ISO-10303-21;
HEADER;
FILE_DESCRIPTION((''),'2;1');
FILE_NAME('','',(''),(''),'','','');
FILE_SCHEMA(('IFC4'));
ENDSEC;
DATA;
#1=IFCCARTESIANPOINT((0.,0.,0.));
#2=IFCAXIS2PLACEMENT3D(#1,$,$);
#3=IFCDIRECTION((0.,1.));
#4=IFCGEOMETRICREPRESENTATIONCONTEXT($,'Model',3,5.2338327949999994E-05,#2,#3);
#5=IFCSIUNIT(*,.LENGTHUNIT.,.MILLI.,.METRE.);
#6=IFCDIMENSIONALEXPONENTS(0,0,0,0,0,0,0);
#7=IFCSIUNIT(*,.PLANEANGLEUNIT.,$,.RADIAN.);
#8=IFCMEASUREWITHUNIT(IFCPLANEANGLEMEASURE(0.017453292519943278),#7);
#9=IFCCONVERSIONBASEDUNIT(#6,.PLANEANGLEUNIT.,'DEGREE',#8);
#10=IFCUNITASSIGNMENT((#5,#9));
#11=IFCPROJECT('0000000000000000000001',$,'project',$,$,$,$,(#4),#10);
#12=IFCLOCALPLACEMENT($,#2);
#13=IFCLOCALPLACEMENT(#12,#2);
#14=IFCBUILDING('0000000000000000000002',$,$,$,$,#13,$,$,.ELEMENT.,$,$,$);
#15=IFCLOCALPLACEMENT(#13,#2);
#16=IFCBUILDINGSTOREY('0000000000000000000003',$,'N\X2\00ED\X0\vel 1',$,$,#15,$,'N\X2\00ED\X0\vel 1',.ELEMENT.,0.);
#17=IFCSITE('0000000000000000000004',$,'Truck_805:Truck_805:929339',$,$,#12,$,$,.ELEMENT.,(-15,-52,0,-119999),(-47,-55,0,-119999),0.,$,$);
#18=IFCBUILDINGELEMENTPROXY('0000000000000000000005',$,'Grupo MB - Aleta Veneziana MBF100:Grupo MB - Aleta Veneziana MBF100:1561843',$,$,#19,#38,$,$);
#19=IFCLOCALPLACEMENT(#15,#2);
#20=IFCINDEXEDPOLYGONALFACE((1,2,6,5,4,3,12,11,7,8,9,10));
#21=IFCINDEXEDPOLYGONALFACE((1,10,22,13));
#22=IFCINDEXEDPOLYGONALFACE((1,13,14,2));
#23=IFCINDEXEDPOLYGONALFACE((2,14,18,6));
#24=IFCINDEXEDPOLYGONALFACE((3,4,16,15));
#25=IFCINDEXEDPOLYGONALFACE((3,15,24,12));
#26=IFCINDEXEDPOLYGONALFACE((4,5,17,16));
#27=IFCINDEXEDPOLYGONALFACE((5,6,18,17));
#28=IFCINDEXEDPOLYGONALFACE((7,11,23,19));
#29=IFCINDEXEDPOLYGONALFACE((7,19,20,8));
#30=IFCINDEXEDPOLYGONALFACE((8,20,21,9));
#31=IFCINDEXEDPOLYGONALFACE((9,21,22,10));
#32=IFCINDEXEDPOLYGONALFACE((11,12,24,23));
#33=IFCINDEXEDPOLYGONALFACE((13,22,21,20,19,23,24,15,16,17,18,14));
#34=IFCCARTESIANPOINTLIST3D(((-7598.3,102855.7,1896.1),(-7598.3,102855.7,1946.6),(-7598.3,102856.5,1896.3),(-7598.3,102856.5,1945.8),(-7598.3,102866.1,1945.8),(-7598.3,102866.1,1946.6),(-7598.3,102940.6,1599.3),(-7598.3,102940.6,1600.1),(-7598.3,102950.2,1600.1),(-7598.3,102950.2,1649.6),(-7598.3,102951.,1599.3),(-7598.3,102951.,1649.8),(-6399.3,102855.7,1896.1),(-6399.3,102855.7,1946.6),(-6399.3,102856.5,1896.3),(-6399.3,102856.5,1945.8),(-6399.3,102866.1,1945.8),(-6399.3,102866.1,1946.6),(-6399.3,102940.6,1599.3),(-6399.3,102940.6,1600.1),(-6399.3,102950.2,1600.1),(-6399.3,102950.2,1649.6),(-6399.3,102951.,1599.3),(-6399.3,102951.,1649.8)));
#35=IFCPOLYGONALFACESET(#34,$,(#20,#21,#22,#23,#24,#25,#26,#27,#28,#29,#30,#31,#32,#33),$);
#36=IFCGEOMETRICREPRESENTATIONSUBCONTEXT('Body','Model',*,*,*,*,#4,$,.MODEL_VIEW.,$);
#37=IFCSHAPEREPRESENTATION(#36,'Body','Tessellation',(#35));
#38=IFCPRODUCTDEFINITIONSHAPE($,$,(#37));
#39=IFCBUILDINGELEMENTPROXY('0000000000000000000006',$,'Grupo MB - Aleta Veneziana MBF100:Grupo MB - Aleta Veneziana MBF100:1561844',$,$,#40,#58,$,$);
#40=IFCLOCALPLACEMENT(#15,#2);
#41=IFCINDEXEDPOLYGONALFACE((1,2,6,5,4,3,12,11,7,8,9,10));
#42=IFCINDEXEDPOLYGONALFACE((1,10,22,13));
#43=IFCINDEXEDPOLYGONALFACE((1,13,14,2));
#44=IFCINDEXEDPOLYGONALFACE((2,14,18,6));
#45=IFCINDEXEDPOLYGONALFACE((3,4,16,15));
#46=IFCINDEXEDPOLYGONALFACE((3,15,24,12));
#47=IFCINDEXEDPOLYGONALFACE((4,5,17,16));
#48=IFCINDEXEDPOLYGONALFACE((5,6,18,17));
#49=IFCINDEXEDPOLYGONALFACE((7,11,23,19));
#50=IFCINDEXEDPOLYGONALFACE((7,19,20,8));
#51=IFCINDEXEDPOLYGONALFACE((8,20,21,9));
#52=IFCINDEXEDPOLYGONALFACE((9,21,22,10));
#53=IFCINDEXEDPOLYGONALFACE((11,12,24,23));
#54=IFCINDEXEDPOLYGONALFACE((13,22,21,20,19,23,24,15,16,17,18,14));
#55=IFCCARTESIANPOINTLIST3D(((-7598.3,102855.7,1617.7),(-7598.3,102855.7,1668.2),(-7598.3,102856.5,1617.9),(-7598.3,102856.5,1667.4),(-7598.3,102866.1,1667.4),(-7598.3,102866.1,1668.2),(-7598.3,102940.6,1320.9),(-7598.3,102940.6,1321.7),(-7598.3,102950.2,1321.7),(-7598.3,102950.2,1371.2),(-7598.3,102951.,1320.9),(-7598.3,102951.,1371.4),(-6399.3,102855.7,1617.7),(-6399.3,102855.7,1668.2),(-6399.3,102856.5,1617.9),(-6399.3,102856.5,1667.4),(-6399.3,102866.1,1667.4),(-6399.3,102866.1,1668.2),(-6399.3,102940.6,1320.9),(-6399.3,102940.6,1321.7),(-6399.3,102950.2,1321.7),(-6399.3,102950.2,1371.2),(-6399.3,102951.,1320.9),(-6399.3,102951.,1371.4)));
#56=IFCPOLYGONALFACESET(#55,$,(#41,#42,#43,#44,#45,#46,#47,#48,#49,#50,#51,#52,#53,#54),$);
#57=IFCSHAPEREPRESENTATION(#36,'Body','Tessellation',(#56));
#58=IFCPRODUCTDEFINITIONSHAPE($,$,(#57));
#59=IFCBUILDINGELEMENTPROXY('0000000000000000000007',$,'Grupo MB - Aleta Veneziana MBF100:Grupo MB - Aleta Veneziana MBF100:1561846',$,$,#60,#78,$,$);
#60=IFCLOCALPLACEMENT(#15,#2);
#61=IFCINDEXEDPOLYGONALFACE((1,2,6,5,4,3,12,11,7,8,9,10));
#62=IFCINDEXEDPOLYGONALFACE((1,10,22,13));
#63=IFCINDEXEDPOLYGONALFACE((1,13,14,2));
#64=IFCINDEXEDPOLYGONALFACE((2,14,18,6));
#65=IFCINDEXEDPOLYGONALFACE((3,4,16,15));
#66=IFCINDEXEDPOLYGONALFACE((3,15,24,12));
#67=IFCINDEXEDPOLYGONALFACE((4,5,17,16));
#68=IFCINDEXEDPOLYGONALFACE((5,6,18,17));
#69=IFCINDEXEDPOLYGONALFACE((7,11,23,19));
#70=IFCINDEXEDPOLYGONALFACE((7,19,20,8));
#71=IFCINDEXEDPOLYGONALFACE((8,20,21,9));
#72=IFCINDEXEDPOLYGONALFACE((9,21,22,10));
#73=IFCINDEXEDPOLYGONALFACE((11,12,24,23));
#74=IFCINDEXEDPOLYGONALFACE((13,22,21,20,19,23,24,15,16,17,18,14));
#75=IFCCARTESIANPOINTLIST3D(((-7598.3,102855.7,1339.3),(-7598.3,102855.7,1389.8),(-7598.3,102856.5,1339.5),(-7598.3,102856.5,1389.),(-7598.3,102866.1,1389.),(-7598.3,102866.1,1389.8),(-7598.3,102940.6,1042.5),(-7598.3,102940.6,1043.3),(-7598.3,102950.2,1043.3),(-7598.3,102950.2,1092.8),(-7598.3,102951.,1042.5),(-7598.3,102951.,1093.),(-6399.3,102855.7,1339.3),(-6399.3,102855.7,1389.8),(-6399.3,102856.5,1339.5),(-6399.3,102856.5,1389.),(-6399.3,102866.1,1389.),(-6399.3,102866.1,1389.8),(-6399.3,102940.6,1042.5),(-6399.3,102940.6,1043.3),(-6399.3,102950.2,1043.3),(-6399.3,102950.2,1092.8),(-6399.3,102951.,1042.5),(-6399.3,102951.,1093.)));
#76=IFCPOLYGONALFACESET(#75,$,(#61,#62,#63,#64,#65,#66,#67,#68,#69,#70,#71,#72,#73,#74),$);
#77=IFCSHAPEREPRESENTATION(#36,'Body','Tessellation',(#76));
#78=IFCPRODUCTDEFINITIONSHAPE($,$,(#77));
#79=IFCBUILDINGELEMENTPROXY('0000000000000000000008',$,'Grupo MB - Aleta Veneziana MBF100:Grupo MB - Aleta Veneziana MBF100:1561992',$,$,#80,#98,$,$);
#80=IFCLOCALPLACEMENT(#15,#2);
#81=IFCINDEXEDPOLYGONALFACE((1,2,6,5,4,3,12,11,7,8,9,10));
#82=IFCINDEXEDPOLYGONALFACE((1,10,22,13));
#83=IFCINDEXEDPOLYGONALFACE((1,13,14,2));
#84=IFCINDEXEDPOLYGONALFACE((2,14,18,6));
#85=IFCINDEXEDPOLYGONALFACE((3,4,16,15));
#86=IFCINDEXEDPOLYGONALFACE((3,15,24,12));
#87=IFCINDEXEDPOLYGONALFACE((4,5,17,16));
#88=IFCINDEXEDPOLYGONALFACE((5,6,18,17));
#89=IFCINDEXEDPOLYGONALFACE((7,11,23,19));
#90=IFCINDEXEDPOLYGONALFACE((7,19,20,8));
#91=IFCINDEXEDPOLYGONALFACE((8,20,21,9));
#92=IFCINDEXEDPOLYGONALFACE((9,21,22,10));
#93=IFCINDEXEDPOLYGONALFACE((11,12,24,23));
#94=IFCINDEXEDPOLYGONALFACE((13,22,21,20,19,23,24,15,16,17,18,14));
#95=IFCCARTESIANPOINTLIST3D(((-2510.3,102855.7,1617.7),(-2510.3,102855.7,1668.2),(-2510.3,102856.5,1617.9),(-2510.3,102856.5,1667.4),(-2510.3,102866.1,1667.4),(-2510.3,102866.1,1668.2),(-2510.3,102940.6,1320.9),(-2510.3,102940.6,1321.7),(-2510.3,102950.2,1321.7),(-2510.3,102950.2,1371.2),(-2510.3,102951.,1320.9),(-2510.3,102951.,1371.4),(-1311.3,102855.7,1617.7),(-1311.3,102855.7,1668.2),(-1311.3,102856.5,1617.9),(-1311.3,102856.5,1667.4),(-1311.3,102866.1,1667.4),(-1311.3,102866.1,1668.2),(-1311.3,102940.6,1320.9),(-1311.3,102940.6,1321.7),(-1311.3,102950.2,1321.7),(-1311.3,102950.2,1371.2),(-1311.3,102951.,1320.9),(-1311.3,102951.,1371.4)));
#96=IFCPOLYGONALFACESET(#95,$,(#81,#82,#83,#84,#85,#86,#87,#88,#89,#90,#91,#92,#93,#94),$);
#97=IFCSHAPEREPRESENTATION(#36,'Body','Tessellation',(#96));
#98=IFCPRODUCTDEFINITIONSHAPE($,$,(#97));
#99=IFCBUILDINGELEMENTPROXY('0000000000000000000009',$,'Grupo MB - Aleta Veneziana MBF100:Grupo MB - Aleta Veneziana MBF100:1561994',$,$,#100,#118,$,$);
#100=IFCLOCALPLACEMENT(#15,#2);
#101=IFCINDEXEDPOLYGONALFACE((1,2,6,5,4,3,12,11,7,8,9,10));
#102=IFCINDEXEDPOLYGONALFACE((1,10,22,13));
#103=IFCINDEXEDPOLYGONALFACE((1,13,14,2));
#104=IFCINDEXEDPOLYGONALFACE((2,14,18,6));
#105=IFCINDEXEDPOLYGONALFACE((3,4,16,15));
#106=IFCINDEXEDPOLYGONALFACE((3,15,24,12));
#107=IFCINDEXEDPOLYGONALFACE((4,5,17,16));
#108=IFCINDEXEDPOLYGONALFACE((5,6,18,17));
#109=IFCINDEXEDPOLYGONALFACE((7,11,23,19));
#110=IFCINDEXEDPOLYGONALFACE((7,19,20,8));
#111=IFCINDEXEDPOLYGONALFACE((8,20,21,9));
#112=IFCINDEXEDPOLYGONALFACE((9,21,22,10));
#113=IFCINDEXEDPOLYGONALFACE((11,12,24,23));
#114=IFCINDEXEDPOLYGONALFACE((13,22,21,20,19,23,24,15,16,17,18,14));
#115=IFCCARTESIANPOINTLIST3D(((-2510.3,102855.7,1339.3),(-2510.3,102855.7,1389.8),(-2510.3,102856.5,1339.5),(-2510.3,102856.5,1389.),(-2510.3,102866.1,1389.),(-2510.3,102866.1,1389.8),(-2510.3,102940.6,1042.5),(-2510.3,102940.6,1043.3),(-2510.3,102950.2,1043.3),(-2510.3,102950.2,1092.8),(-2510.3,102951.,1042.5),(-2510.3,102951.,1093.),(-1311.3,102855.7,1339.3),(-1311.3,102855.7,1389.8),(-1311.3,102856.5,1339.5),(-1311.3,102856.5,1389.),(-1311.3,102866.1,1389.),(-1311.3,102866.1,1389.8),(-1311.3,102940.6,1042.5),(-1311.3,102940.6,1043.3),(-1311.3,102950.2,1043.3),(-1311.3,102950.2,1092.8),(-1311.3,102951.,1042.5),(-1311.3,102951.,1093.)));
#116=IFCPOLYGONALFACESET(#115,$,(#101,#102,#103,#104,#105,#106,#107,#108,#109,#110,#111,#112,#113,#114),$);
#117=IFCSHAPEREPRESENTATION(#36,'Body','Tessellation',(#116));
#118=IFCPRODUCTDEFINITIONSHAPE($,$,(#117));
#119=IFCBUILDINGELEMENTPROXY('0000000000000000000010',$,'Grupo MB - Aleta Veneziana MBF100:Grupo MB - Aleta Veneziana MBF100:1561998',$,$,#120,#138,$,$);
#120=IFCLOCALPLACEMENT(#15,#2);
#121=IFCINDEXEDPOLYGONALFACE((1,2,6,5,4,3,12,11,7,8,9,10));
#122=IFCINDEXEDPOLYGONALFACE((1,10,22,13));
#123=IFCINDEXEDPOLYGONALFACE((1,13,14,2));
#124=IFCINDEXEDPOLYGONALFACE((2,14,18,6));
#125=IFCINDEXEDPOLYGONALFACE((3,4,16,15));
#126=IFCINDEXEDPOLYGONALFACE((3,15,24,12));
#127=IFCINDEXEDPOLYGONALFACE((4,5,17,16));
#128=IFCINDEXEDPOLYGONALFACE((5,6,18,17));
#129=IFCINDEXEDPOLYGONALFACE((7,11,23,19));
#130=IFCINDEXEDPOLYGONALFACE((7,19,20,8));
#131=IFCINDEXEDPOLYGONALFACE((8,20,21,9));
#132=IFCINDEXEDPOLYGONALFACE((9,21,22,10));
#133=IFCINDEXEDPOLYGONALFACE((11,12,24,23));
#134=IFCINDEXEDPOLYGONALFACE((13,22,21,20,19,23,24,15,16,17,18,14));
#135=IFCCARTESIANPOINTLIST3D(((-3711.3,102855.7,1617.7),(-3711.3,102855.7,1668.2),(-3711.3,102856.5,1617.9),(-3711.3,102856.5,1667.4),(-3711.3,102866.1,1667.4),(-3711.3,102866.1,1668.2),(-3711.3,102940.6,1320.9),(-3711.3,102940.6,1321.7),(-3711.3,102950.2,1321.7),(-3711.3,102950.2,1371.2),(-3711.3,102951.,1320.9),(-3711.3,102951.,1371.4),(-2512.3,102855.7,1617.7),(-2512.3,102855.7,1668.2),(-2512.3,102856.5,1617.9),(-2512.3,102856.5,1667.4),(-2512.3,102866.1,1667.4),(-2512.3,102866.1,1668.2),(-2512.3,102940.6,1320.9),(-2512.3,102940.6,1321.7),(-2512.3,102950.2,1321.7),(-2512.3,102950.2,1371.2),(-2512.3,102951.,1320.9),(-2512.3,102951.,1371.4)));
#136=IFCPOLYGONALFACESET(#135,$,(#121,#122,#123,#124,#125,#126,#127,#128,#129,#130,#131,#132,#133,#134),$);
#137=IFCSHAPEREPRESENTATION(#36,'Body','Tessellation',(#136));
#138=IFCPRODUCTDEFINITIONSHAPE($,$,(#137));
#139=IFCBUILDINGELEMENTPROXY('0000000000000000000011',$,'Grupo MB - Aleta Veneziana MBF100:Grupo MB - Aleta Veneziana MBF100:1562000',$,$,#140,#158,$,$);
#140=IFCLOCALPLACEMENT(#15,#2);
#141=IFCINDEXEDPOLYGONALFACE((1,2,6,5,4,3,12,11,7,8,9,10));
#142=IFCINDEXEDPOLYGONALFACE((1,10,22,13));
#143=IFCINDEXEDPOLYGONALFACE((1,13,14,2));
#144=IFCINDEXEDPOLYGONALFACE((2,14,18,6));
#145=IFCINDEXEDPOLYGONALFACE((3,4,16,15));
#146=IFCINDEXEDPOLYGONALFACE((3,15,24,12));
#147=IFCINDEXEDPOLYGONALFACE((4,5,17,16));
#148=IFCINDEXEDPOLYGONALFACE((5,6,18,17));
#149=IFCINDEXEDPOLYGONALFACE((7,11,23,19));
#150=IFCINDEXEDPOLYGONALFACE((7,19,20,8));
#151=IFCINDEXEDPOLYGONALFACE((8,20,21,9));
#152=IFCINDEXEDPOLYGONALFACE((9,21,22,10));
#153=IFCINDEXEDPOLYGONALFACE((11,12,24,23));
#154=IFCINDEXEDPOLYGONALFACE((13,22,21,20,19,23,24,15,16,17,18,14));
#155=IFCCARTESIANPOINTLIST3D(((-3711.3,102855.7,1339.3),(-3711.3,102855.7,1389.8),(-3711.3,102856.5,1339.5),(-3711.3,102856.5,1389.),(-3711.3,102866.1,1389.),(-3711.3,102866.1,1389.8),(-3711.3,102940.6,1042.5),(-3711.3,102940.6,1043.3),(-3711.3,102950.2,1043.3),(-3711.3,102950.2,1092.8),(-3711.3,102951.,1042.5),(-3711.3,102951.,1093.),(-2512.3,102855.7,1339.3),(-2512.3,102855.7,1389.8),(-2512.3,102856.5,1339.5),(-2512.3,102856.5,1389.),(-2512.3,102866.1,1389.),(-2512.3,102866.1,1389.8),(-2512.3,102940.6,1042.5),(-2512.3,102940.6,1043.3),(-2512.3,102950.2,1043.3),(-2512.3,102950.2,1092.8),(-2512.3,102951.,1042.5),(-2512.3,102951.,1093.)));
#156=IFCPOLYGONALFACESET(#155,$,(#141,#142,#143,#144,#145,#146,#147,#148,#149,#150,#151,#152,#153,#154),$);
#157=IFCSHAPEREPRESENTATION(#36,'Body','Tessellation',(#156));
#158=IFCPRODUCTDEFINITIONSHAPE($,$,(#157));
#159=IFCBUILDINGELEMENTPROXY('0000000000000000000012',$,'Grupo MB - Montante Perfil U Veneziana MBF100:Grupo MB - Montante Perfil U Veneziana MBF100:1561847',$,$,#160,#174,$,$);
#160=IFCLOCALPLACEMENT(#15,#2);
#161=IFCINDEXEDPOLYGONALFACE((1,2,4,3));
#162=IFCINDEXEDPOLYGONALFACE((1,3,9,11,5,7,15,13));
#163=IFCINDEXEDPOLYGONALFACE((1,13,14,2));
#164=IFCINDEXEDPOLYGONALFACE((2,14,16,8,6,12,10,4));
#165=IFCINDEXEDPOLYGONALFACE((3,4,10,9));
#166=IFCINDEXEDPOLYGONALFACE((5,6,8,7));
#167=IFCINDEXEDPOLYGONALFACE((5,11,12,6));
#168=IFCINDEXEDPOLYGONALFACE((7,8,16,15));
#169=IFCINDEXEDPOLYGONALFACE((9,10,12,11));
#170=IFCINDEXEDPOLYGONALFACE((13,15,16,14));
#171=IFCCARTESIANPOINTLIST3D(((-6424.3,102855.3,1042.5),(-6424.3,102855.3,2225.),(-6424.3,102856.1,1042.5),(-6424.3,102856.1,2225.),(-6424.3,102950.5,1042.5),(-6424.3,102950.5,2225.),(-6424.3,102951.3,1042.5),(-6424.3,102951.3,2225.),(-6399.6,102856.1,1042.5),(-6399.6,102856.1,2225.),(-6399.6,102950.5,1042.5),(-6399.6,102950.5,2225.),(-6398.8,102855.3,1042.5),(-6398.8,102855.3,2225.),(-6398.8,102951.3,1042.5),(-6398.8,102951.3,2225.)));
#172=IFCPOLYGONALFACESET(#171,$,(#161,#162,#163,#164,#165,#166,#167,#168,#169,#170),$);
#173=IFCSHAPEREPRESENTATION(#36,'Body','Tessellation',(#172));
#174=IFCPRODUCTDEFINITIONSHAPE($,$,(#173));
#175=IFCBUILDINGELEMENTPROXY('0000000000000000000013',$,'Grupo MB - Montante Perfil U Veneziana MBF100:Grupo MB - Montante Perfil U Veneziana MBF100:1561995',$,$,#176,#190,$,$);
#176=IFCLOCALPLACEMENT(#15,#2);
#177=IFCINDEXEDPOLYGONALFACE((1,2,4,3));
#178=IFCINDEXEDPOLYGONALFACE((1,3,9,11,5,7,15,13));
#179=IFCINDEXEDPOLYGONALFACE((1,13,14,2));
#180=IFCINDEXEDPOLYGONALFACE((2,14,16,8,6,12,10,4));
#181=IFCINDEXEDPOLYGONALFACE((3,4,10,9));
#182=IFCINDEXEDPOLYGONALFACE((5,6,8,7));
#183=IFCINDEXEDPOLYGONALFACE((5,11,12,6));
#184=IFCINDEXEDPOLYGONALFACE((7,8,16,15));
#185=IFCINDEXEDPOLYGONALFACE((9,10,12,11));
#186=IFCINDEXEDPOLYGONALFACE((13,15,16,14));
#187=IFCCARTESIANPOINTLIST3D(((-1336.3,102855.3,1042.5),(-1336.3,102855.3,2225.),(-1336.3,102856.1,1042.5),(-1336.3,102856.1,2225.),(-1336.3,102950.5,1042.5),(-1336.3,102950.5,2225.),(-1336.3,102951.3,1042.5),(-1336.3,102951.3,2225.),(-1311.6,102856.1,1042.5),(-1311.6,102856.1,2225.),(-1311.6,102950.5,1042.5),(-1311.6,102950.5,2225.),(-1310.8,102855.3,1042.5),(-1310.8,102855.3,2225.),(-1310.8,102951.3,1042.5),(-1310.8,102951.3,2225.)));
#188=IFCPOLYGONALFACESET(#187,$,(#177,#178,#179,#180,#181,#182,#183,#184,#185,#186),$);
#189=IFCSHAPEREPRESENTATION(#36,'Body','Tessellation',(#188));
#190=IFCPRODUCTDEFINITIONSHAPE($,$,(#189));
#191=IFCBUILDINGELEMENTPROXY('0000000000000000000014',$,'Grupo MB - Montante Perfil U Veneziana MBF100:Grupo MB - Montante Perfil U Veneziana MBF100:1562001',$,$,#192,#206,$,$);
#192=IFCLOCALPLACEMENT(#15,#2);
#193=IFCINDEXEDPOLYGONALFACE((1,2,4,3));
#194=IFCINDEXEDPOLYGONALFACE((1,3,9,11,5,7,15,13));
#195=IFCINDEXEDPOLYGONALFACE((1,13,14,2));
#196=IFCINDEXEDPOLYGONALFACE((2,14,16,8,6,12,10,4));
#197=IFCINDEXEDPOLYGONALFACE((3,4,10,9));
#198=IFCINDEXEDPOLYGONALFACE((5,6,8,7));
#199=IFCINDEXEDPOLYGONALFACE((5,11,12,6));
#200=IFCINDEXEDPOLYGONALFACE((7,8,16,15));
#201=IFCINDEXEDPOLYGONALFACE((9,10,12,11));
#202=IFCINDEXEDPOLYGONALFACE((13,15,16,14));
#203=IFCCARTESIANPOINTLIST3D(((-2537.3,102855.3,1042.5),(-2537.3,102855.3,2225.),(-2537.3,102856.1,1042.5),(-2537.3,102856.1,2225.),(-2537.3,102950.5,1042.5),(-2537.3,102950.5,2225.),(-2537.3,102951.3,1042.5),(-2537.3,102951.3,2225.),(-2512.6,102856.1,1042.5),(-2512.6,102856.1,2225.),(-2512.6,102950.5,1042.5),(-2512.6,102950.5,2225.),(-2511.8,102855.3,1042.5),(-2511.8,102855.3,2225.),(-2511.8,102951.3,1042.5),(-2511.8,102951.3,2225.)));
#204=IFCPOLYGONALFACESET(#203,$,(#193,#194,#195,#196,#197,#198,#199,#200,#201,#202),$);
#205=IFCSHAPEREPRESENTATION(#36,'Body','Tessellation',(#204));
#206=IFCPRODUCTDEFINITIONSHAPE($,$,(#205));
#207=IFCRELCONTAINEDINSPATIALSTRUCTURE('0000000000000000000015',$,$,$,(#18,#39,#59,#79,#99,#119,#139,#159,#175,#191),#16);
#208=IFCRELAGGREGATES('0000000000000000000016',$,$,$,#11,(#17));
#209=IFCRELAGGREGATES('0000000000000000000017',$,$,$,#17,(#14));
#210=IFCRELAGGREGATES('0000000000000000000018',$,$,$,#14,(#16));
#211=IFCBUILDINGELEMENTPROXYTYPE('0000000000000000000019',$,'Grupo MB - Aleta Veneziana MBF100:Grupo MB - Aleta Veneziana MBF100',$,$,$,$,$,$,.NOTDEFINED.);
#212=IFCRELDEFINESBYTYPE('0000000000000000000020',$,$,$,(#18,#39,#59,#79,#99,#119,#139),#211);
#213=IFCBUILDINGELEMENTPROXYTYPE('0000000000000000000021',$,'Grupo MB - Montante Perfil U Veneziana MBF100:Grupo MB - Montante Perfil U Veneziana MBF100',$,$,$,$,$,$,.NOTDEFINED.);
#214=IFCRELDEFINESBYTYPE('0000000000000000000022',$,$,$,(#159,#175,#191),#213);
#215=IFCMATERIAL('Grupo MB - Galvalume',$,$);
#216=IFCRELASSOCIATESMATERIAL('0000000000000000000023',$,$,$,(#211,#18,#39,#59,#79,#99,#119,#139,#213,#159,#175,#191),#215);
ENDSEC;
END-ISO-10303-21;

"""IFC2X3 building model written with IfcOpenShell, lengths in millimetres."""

from ifc_helpers import new_model, entity, si_unit, converted_unit, direction, frame, origin, place, context, subcontext, project, spatial, polyline, outline, extrude, source, transform, mapped, material, type_object, type_shapes, element, save


model = new_model("IFC2X3")

# Units and contexts
model_context = context("Model", 3, precision=5.2338327949999994e-05, world=origin(), true_north=direction((0.0, 1.0)))
body_context = subcontext(model_context, "Body", "Model", "MODEL_VIEW")
ifc_project = project(units=[si_unit("LENGTHUNIT", "METRE", prefix="MILLI"), converted_unit("PLANEANGLEUNIT", "DEGREE", entity("IfcPlaneAngleMeasure", 0.017453292519943278), si_unit("PLANEANGLEUNIT", "RADIAN"), dimensions=[0, 0, 0, 0, 0, 0, 0])], contexts=[model_context])

# Site, building, storey
site_placement = place(None, origin())
site = spatial("IfcSite", under=ifc_project, at=site_placement, Name="Truck_805:Truck_805:929339", CompositionType="ELEMENT", RefLatitude=(-15, -52, 0, -119999), RefLongitude=(-47, -55, 0, -119999), RefElevation=0.0)
building_placement = place(site_placement, origin())
building = spatial("IfcBuilding", under=site, at=building_placement, CompositionType="ELEMENT")
storey_placement = place(building_placement, origin())
storey = spatial("IfcBuildingStorey", under=building, at=storey_placement, Name="Nível 1", LongName="Nível 1", CompositionType="ELEMENT", Elevation=0.0)

# Building element proxies
ifc_material_1 = material(Name="Grupo MB - Galvalume")
building_element_proxy_type_1 = type_object("IfcBuildingElementProxyType", Name="Grupo MB - Aleta Veneziana MBF100:Grupo MB - Aleta Veneziana MBF100", PredefinedType="NOTDEFINED", material=ifc_material_1)
shared_shape_1 = source(origin(), body_context, "Body", "SweptSolid", [
    extrude(outline(polyline([(-131.9, -0.4), (132.1, -0.4), (179.2, 17.7), (175.5, 27.4), (174.7, 27.1), (178.2, 18.1), (131.9, 0.4), (-132.1, 0.4), (-179.2, -17.7), (-175.5, -27.4), (-174.7, -27.1), (-178.2, -18.1), (-131.9, -0.4)])), frame((0.0, -47.6, 173.7), z_axis=(1.0, 0.0, 0.0), x_axis=(0.0, 0.357955, 0.933739)), (0.0, 0.0, 1.0), 1199.0),
])
type_shapes(building_element_proxy_type_1, [shared_shape_1])
for number, where, z_axis, x_axis, name in (
    (1, (-6399.3, 102855.7, 1599.3), (0.0, 0.0, 1.0), (-1.0, 0.0, 0.0), "Grupo MB - Aleta Veneziana MBF100:Grupo MB - Aleta Veneziana MBF100:1561843"),
    (2, (-6399.3, 102855.7, 1320.9), (0.0, 0.0, 1.0), (-1.0, 0.0, 0.0), "Grupo MB - Aleta Veneziana MBF100:Grupo MB - Aleta Veneziana MBF100:1561844"),
    (3, (-6399.3, 102855.7, 1042.5), (0.0, 0.0, 1.0), (-1.0, 0.0, 0.0), "Grupo MB - Aleta Veneziana MBF100:Grupo MB - Aleta Veneziana MBF100:1561846"),
    (4, (-1311.3, 102855.7, 1320.9), (0.0, 0.0, 1.0), (-1.0, 0.0, 0.0), "Grupo MB - Aleta Veneziana MBF100:Grupo MB - Aleta Veneziana MBF100:1561992"),
    (5, (-1311.3, 102855.7, 1042.5), (0.0, 0.0, 1.0), (-1.0, 0.0, 0.0), "Grupo MB - Aleta Veneziana MBF100:Grupo MB - Aleta Veneziana MBF100:1561994"),
    (6, (-2512.3, 102855.7, 1320.9), (0.0, 0.0, 1.0), (-1.0, 0.0, 0.0), "Grupo MB - Aleta Veneziana MBF100:Grupo MB - Aleta Veneziana MBF100:1561998"),
    (7, (-2512.3, 102855.7, 1042.5), (0.0, 0.0, 1.0), (-1.0, 0.0, 0.0), "Grupo MB - Aleta Veneziana MBF100:Grupo MB - Aleta Veneziana MBF100:1562000"),
):
    element("IfcBuildingElementProxy", number, at=place(storey_placement, frame(where, z_axis=z_axis, x_axis=x_axis)), inside=storey, type_object=building_element_proxy_type_1, material=ifc_material_1, Name=name, context=body_context, shape_type="MappedRepresentation", body=[
        mapped(shared_shape_1, transform((0.0, 0.0, 0.0), scale=1.0)),
    ])
building_element_proxy_type_2 = type_object("IfcBuildingElementProxyType", Name="Grupo MB - Montante Perfil U Veneziana MBF100:Grupo MB - Montante Perfil U Veneziana MBF100", PredefinedType="NOTDEFINED", material=ifc_material_1)
shared_shape_2 = source(origin(), body_context, "Body", "SweptSolid", [
    extrude(outline(polyline([(-48.0, -13.0), (48.0, -13.0), (48.0, 12.6), (47.2, 12.6), (47.2, -12.2), (-47.2, -12.2), (-47.2, 12.6), (-48.0, 12.6), (-48.0, -13.0)])), frame((0.0, -48.0, 13.0), z_axis=(1.0, 0.0, 0.0), x_axis=(0.0, 1.0, 0.0)), (0.0, 0.0, 1.0), 1182.5),
])
type_shapes(building_element_proxy_type_2, [shared_shape_2])
for number, where, z_axis, x_axis, name in (
    (8, (-6398.8, 102951.3, 1042.5), (-1.0, 0.0, 0.0), (0.0, 0.0, 1.0), "Grupo MB - Montante Perfil U Veneziana MBF100:Grupo MB - Montante Perfil U Veneziana MBF100:1561847"),
    (9, (-1310.8, 102951.3, 1042.5), (-1.0, 0.0, 0.0), (0.0, 0.0, 1.0), "Grupo MB - Montante Perfil U Veneziana MBF100:Grupo MB - Montante Perfil U Veneziana MBF100:1561995"),
    (10, (-2511.8, 102951.3, 1042.5), (-1.0, 0.0, 0.0), (0.0, 0.0, 1.0), "Grupo MB - Montante Perfil U Veneziana MBF100:Grupo MB - Montante Perfil U Veneziana MBF100:1562001"),
):
    element("IfcBuildingElementProxy", number, at=place(storey_placement, frame(where, z_axis=z_axis, x_axis=x_axis)), inside=storey, type_object=building_element_proxy_type_2, material=ifc_material_1, Name=name, context=body_context, shape_type="MappedRepresentation", body=[
        mapped(shared_shape_2, transform((0.0, 0.0, 0.0), scale=1.0)),
    ])

save(model, "model.ifc")
